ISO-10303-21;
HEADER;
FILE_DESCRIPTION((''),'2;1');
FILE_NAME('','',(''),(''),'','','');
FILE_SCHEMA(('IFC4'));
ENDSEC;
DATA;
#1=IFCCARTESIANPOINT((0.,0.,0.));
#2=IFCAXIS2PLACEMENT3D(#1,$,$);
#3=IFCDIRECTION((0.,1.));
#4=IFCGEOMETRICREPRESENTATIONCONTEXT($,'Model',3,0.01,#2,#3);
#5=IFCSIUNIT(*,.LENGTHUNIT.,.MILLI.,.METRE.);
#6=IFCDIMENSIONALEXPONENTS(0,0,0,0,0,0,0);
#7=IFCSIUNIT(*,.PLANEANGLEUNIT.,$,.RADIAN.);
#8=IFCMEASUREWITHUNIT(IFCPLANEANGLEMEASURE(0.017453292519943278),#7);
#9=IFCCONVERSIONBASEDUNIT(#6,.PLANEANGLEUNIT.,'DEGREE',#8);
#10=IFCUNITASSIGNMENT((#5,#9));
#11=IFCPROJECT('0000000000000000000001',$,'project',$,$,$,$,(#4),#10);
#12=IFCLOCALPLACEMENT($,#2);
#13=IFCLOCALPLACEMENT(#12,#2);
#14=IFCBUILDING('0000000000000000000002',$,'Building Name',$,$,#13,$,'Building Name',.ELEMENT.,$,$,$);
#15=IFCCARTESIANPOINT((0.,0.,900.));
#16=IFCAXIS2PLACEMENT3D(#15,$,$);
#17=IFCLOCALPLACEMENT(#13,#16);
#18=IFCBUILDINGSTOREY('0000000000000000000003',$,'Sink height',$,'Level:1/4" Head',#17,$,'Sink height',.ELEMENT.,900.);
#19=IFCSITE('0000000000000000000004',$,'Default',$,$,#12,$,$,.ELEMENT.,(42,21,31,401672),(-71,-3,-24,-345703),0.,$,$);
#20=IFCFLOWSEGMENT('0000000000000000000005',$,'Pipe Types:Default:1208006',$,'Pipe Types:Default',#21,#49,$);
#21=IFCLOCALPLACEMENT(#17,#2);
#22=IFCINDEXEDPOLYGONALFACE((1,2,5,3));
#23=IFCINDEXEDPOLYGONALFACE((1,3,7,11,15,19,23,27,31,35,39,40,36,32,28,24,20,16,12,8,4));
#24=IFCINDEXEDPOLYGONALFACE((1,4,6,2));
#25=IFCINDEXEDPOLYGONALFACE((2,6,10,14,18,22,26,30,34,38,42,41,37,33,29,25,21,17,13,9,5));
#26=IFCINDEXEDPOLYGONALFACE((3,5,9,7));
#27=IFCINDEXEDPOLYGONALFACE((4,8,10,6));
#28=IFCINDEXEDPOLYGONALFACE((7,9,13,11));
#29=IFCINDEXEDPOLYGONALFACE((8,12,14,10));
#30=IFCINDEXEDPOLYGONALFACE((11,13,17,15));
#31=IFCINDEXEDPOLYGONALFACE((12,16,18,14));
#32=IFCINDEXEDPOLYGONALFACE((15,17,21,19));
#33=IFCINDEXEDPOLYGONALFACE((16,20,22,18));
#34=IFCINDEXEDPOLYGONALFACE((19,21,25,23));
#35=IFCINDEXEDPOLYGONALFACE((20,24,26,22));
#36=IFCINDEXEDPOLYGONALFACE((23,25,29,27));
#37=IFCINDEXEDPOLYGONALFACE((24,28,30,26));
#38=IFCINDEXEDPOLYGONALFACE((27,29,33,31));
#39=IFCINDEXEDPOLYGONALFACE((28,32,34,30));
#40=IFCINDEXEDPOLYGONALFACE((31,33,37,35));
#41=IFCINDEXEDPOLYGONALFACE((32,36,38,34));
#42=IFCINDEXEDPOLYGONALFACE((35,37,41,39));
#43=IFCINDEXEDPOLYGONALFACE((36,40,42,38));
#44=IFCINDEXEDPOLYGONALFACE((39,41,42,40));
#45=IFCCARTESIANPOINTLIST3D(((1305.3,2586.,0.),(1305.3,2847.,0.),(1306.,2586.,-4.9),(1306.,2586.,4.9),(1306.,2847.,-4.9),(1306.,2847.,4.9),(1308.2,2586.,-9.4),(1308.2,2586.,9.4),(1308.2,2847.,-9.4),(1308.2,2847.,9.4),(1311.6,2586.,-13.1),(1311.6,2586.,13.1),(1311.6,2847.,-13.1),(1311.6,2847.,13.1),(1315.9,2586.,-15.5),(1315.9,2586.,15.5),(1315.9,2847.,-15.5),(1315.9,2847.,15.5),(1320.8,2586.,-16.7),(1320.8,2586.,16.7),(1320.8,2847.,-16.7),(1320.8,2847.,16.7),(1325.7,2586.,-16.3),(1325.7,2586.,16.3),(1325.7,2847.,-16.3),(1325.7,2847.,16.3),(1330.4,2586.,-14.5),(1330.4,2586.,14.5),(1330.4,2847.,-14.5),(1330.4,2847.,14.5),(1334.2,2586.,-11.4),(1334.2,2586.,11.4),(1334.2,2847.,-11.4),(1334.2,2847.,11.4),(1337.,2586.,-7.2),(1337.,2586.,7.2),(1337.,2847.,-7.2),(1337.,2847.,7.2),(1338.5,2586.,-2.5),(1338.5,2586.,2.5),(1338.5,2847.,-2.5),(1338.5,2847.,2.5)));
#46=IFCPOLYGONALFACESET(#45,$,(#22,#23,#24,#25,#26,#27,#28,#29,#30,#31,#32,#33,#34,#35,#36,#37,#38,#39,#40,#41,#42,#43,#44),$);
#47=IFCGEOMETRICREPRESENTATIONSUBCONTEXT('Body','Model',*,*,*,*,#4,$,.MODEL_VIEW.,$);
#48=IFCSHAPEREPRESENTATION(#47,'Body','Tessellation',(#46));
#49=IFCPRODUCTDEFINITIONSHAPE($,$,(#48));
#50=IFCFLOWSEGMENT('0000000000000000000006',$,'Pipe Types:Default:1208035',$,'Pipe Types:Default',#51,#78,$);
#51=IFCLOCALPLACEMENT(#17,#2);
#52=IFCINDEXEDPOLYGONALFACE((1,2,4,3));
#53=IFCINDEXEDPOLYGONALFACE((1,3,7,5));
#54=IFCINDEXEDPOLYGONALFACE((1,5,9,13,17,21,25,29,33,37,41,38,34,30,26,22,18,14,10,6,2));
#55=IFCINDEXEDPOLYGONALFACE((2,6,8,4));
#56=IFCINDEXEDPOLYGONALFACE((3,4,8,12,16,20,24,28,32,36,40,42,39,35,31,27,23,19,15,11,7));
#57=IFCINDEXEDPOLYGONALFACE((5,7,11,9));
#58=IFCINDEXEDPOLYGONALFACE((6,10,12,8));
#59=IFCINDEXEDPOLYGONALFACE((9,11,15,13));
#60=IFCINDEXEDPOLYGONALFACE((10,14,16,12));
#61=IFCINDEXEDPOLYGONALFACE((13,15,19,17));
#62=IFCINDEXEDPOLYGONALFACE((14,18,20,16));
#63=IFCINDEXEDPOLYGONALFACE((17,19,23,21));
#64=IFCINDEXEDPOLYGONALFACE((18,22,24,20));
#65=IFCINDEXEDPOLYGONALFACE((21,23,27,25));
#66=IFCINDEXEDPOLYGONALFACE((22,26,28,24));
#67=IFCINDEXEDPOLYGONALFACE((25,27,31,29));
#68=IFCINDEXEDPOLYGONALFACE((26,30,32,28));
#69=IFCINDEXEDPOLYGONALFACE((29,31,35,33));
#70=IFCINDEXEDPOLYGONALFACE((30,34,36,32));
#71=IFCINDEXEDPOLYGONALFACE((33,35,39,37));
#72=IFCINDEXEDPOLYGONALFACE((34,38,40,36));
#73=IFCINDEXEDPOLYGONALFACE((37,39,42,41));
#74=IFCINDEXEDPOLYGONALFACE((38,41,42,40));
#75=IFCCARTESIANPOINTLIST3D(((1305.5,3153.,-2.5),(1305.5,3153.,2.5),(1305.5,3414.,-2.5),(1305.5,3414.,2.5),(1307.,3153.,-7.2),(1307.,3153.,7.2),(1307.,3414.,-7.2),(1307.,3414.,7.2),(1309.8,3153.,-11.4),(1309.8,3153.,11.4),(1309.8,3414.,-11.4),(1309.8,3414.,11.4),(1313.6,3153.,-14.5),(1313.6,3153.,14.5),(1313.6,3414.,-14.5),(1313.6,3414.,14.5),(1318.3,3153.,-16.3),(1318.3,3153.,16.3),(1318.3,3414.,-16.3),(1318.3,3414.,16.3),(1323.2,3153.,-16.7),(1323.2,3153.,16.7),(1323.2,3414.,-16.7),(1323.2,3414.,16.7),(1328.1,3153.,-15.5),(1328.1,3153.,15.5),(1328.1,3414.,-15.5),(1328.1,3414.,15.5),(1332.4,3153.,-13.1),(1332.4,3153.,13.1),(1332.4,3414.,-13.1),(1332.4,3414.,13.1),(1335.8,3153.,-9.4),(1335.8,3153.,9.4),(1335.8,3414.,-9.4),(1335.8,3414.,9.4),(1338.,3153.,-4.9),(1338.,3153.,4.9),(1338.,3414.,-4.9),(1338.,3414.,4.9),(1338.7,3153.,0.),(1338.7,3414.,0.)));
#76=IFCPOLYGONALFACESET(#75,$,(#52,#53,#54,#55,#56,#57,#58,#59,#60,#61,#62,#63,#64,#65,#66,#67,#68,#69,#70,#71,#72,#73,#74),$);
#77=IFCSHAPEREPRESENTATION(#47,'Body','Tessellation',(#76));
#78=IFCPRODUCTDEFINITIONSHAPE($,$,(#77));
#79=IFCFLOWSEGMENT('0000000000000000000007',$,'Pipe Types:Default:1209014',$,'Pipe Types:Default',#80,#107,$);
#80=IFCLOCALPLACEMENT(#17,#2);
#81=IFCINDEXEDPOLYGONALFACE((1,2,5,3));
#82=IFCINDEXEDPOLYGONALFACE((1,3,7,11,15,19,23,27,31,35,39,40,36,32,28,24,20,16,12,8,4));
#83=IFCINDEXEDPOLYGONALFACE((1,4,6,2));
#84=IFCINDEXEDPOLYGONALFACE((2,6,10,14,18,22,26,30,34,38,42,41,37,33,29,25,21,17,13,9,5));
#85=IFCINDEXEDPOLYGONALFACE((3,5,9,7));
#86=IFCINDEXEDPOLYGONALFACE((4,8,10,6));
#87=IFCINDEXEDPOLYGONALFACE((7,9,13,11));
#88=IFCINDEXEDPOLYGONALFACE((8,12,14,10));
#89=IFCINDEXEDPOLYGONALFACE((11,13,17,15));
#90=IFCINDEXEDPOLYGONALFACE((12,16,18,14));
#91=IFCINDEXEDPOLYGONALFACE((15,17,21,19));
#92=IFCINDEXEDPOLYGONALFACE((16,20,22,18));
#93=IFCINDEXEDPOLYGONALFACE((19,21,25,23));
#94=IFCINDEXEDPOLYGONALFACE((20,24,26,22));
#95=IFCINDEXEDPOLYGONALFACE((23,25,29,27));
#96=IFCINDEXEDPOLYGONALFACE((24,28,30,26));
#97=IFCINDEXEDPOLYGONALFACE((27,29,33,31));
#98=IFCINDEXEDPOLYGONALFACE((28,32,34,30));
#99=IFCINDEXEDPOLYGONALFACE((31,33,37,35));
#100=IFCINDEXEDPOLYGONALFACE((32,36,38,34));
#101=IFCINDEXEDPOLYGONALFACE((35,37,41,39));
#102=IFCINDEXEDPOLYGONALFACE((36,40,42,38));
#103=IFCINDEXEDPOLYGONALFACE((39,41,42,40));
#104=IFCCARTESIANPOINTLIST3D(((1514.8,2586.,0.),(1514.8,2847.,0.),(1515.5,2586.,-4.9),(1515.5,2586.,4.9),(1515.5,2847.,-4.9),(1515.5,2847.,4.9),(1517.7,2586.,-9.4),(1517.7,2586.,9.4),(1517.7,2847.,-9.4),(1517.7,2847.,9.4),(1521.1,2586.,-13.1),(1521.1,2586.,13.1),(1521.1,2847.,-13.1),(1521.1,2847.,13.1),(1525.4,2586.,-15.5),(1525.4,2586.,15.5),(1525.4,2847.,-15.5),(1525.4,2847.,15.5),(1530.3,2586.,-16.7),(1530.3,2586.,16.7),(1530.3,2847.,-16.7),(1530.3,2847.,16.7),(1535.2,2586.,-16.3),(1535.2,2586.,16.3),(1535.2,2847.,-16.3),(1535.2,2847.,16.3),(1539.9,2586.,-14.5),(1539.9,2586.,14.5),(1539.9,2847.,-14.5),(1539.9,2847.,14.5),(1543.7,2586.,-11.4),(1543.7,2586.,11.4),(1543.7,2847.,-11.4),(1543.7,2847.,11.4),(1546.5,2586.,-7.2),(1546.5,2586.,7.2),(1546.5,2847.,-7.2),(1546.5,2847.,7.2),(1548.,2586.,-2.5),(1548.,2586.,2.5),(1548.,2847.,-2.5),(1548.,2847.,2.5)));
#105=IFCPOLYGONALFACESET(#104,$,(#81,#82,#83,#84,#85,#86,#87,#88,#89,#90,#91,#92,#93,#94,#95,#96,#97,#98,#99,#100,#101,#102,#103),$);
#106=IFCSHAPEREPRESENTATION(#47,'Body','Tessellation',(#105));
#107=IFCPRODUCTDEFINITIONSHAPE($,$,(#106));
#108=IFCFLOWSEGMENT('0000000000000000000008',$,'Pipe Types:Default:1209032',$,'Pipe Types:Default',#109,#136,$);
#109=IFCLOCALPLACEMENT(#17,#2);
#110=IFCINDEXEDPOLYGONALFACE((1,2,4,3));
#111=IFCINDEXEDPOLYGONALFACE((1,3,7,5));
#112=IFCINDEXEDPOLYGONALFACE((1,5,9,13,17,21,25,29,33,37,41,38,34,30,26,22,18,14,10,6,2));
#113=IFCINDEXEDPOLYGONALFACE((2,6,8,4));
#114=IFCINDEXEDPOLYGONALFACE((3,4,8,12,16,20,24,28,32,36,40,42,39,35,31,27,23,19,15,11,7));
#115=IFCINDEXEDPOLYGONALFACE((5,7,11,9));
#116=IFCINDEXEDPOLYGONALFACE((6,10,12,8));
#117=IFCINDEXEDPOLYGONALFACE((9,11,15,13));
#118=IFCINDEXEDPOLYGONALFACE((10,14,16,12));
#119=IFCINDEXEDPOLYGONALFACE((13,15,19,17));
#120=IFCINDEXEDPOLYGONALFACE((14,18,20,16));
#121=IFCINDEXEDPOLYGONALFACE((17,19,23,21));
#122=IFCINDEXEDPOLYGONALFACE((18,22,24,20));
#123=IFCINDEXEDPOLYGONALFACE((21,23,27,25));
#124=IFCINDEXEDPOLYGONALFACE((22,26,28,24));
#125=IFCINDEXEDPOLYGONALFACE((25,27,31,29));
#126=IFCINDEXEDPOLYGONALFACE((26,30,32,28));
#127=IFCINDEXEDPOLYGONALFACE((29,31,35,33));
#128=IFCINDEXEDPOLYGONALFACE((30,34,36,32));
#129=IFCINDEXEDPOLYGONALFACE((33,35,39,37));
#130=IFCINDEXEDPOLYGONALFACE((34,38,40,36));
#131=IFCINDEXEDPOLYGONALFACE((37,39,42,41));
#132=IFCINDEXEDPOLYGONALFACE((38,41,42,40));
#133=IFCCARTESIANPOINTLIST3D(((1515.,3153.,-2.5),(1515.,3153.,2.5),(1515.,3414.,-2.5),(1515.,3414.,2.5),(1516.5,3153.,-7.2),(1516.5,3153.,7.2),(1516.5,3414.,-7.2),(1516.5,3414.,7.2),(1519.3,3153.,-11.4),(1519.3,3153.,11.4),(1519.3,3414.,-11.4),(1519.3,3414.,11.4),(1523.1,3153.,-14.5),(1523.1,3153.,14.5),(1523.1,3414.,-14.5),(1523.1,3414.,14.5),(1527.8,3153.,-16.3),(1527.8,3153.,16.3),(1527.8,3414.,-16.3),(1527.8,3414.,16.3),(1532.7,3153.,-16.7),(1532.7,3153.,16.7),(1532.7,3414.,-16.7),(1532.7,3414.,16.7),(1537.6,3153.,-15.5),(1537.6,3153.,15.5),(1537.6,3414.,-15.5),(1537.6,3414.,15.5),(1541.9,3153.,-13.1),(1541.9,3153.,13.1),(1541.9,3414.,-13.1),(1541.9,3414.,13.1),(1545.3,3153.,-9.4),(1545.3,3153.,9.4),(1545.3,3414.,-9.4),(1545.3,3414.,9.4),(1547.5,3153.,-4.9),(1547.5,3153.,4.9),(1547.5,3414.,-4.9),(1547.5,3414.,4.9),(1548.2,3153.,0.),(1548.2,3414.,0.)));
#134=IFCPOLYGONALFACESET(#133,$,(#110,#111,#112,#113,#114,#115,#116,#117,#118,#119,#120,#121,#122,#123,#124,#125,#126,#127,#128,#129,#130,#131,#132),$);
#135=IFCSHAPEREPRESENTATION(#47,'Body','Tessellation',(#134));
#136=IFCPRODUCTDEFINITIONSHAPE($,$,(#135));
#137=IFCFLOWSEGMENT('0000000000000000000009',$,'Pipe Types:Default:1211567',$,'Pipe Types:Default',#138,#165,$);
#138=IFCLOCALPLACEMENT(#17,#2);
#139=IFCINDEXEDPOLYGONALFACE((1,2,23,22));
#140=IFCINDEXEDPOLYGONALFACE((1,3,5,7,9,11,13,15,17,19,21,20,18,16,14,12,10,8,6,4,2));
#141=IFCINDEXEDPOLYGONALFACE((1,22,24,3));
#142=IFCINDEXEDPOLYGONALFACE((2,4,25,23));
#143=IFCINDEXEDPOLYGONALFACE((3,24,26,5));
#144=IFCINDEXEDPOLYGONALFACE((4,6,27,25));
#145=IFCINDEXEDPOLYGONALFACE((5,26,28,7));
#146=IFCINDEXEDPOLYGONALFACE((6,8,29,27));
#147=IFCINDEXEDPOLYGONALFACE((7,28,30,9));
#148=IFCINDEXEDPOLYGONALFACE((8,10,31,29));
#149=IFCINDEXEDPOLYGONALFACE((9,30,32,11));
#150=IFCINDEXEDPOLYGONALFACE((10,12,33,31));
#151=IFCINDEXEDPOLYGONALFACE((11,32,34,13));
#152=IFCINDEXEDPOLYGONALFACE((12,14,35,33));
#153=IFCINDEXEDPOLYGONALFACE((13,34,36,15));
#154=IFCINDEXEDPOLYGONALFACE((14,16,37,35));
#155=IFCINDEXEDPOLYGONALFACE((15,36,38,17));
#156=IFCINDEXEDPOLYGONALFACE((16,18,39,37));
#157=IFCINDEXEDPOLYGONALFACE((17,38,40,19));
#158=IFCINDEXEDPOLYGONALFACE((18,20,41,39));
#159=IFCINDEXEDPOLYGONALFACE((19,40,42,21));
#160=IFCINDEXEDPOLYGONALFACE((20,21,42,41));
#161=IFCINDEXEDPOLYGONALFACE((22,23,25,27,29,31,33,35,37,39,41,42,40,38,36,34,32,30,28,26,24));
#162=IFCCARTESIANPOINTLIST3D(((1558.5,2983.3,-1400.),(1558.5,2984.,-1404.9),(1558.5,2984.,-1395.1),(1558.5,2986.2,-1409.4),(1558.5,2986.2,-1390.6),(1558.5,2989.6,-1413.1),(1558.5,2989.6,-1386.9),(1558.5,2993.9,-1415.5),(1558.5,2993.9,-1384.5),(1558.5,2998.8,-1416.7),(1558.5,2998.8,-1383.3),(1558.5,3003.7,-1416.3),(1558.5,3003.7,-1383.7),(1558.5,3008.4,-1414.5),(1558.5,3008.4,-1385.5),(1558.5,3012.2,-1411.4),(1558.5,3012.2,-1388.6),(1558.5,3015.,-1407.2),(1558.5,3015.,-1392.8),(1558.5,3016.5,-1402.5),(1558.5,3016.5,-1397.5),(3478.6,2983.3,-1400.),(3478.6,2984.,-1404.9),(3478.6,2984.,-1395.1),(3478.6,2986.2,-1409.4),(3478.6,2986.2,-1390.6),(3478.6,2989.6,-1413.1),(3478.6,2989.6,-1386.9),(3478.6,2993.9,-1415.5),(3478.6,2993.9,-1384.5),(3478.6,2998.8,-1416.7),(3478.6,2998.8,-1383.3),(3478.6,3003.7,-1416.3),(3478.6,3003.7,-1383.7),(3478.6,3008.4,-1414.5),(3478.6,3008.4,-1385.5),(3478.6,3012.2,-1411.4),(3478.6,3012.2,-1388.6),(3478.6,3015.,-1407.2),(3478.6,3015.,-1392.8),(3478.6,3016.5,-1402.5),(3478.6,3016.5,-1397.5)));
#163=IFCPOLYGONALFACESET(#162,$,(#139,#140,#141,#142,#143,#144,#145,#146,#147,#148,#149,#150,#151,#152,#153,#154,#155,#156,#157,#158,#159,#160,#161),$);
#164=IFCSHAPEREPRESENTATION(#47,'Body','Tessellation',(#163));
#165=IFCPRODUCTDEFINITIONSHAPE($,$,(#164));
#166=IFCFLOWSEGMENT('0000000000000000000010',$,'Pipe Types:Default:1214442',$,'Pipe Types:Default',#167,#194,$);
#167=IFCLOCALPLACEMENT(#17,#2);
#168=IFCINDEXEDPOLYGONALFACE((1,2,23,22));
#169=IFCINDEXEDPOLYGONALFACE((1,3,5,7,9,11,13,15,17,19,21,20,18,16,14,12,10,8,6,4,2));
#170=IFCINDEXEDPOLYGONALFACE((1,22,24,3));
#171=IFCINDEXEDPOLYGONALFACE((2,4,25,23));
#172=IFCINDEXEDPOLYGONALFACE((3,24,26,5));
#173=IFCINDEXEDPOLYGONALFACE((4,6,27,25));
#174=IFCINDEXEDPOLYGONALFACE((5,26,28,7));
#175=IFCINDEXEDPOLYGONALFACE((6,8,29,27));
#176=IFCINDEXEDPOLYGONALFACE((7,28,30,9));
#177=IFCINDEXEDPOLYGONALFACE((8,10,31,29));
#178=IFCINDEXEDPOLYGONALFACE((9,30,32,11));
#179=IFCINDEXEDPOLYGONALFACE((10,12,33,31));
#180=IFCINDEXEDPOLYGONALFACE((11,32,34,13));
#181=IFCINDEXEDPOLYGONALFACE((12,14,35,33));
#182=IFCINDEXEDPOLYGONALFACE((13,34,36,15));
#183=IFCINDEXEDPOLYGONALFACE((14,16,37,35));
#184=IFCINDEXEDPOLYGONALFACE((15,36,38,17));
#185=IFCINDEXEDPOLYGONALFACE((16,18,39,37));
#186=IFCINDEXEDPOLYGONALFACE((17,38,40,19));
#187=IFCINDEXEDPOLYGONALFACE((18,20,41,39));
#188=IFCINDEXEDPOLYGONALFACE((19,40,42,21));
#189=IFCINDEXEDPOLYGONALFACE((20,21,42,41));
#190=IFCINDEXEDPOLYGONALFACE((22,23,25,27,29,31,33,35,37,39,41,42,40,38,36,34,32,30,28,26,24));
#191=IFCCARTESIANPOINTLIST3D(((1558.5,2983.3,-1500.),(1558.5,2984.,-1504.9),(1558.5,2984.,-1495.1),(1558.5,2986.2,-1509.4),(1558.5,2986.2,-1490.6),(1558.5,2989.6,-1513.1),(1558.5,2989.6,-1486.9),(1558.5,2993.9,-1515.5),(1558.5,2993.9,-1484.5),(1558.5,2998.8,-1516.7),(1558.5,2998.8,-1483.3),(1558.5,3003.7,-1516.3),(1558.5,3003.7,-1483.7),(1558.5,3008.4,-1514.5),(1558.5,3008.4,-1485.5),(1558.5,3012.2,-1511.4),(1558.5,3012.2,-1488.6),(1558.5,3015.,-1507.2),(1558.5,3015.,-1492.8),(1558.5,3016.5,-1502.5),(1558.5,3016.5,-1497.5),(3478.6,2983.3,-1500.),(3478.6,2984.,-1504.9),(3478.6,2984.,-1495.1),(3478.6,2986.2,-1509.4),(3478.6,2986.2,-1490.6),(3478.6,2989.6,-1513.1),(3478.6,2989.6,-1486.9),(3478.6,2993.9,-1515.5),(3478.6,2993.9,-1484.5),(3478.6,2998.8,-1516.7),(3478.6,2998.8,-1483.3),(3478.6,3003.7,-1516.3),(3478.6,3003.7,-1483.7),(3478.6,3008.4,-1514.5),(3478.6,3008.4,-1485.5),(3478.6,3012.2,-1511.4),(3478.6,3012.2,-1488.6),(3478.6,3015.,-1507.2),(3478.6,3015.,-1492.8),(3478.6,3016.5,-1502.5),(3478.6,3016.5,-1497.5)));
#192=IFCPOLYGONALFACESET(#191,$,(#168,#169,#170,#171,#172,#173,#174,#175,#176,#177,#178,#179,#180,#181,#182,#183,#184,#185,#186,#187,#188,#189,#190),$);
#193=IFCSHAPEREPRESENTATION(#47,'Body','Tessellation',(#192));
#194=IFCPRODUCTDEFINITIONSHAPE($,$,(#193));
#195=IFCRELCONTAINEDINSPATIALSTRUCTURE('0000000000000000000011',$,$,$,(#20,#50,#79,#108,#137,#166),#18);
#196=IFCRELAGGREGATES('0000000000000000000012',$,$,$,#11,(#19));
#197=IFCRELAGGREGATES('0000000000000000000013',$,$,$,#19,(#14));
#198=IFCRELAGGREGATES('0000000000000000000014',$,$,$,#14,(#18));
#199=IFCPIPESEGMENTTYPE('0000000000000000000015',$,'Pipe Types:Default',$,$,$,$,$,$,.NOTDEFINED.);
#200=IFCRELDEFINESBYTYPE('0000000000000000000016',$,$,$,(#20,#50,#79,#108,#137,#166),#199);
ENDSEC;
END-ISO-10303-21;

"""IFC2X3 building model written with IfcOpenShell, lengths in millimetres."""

from ifc_helpers import new_model, entity, si_unit, converted_unit, direction, frame, frame_2d, origin, origin_2d_with_axis, place, context, subcontext, project, spatial, circle, extrude, type_object, element, save


model = new_model("IFC2X3")

# Units and contexts
model_context = context("Model", 3, precision=0.01, world=origin(), true_north=direction((0.0, 1.0)))
body_context = subcontext(model_context, "Body", "Model", "MODEL_VIEW")
ifc_project = project(units=[si_unit("LENGTHUNIT", "METRE", prefix="MILLI"), converted_unit("PLANEANGLEUNIT", "DEGREE", entity("IfcPlaneAngleMeasure", 0.017453292519943278), si_unit("PLANEANGLEUNIT", "RADIAN"), dimensions=[0, 0, 0, 0, 0, 0, 0])], contexts=[model_context])

# Site, building, storey
site_placement = place(None, origin())
site = spatial("IfcSite", under=ifc_project, at=site_placement, Name="Default", CompositionType="ELEMENT", RefLatitude=(42, 21, 31, 401672), RefLongitude=(-71, -3, -24, -345703), RefElevation=0.0)
building_placement = place(site_placement, origin())
building = spatial("IfcBuilding", under=site, at=building_placement, Name="Building Name", LongName="Building Name", CompositionType="ELEMENT")
storey_placement = place(building_placement, frame((0.0, 0.0, 900.0)))
storey = spatial("IfcBuildingStorey", under=building, at=storey_placement, Name="Sink height", ObjectType="Level:1/4\" Head", LongName="Sink height", CompositionType="ELEMENT", Elevation=900.0)

# Flow segments
pipe_segment_type = type_object("IfcPipeSegmentType", Name="Pipe Types:Default", PredefinedType="NOTDEFINED")
flow_segment_1_placement = place(storey_placement, origin())
element("IfcFlowSegment", 1, at=flow_segment_1_placement, inside=storey, type_object=pipe_segment_type, Name="Pipe Types:Default:1208006", ObjectType="Pipe Types:Default", context=body_context, shape_type="SweptSolid", body=[
    extrude(circle(Radius=16.7, at=frame_2d((0.0, 0.0), x_axis=(1.0, 0.0))), frame((1322.0, 2586.0, 0.0), z_axis=(0.0, 1.0, 0.0), x_axis=(-1.0, 0.0, 0.0)), (0.0, 0.0, 1.0), 261.0),
])
flow_segment_2_placement = place(storey_placement, origin())
element("IfcFlowSegment", 2, at=flow_segment_2_placement, inside=storey, type_object=pipe_segment_type, Name="Pipe Types:Default:1208035", ObjectType="Pipe Types:Default", context=body_context, shape_type="SweptSolid", body=[
    extrude(circle(Radius=16.7, at=origin_2d_with_axis()), frame((1322.0, 3153.0, 0.0), z_axis=(0.0, 1.0, 0.0), x_axis=(1.0, 0.0, 0.0)), (0.0, 0.0, 1.0), 261.0),
])
flow_segment_3_placement = place(storey_placement, origin())
element("IfcFlowSegment", 3, at=flow_segment_3_placement, inside=storey, type_object=pipe_segment_type, Name="Pipe Types:Default:1209014", ObjectType="Pipe Types:Default", context=body_context, shape_type="SweptSolid", body=[
    extrude(circle(Radius=16.7, at=frame_2d((0.0, 0.0), x_axis=(1.0, 0.0))), frame((1531.5, 2586.0, 0.0), z_axis=(0.0, 1.0, 0.0), x_axis=(-1.0, 0.0, 0.0)), (0.0, 0.0, 1.0), 261.0),
])
flow_segment_4_placement = place(storey_placement, origin())
element("IfcFlowSegment", 4, at=flow_segment_4_placement, inside=storey, type_object=pipe_segment_type, Name="Pipe Types:Default:1209032", ObjectType="Pipe Types:Default", context=body_context, shape_type="SweptSolid", body=[
    extrude(circle(Radius=16.7, at=origin_2d_with_axis()), frame((1531.5, 3153.0, 0.0), z_axis=(0.0, 1.0, 0.0), x_axis=(1.0, 0.0, 0.0)), (0.0, 0.0, 1.0), 261.0),
])
flow_segment_5_placement = place(storey_placement, origin())
element("IfcFlowSegment", 5, at=flow_segment_5_placement, inside=storey, type_object=pipe_segment_type, Name="Pipe Types:Default:1211567", ObjectType="Pipe Types:Default", context=body_context, shape_type="SweptSolid", body=[
    extrude(circle(Radius=16.7, at=origin_2d_with_axis()), frame((1558.5, 3000.0, -1400.0), z_axis=(1.0, 0.0, 0.0), x_axis=(0.0, -1.0, 0.0)), (0.0, 0.0, 1.0), 1920.1),
])
flow_segment_6_placement = place(storey_placement, origin())
element("IfcFlowSegment", 6, at=flow_segment_6_placement, inside=storey, type_object=pipe_segment_type, Name="Pipe Types:Default:1214442", ObjectType="Pipe Types:Default", context=body_context, shape_type="SweptSolid", body=[
    extrude(circle(Radius=16.7, at=origin_2d_with_axis()), frame((1558.5, 3000.0, -1500.0), z_axis=(1.0, 0.0, 0.0), x_axis=(0.0, -1.0, 0.0)), (0.0, 0.0, 1.0), 1920.1),
])

save(model, "model.ifc")
